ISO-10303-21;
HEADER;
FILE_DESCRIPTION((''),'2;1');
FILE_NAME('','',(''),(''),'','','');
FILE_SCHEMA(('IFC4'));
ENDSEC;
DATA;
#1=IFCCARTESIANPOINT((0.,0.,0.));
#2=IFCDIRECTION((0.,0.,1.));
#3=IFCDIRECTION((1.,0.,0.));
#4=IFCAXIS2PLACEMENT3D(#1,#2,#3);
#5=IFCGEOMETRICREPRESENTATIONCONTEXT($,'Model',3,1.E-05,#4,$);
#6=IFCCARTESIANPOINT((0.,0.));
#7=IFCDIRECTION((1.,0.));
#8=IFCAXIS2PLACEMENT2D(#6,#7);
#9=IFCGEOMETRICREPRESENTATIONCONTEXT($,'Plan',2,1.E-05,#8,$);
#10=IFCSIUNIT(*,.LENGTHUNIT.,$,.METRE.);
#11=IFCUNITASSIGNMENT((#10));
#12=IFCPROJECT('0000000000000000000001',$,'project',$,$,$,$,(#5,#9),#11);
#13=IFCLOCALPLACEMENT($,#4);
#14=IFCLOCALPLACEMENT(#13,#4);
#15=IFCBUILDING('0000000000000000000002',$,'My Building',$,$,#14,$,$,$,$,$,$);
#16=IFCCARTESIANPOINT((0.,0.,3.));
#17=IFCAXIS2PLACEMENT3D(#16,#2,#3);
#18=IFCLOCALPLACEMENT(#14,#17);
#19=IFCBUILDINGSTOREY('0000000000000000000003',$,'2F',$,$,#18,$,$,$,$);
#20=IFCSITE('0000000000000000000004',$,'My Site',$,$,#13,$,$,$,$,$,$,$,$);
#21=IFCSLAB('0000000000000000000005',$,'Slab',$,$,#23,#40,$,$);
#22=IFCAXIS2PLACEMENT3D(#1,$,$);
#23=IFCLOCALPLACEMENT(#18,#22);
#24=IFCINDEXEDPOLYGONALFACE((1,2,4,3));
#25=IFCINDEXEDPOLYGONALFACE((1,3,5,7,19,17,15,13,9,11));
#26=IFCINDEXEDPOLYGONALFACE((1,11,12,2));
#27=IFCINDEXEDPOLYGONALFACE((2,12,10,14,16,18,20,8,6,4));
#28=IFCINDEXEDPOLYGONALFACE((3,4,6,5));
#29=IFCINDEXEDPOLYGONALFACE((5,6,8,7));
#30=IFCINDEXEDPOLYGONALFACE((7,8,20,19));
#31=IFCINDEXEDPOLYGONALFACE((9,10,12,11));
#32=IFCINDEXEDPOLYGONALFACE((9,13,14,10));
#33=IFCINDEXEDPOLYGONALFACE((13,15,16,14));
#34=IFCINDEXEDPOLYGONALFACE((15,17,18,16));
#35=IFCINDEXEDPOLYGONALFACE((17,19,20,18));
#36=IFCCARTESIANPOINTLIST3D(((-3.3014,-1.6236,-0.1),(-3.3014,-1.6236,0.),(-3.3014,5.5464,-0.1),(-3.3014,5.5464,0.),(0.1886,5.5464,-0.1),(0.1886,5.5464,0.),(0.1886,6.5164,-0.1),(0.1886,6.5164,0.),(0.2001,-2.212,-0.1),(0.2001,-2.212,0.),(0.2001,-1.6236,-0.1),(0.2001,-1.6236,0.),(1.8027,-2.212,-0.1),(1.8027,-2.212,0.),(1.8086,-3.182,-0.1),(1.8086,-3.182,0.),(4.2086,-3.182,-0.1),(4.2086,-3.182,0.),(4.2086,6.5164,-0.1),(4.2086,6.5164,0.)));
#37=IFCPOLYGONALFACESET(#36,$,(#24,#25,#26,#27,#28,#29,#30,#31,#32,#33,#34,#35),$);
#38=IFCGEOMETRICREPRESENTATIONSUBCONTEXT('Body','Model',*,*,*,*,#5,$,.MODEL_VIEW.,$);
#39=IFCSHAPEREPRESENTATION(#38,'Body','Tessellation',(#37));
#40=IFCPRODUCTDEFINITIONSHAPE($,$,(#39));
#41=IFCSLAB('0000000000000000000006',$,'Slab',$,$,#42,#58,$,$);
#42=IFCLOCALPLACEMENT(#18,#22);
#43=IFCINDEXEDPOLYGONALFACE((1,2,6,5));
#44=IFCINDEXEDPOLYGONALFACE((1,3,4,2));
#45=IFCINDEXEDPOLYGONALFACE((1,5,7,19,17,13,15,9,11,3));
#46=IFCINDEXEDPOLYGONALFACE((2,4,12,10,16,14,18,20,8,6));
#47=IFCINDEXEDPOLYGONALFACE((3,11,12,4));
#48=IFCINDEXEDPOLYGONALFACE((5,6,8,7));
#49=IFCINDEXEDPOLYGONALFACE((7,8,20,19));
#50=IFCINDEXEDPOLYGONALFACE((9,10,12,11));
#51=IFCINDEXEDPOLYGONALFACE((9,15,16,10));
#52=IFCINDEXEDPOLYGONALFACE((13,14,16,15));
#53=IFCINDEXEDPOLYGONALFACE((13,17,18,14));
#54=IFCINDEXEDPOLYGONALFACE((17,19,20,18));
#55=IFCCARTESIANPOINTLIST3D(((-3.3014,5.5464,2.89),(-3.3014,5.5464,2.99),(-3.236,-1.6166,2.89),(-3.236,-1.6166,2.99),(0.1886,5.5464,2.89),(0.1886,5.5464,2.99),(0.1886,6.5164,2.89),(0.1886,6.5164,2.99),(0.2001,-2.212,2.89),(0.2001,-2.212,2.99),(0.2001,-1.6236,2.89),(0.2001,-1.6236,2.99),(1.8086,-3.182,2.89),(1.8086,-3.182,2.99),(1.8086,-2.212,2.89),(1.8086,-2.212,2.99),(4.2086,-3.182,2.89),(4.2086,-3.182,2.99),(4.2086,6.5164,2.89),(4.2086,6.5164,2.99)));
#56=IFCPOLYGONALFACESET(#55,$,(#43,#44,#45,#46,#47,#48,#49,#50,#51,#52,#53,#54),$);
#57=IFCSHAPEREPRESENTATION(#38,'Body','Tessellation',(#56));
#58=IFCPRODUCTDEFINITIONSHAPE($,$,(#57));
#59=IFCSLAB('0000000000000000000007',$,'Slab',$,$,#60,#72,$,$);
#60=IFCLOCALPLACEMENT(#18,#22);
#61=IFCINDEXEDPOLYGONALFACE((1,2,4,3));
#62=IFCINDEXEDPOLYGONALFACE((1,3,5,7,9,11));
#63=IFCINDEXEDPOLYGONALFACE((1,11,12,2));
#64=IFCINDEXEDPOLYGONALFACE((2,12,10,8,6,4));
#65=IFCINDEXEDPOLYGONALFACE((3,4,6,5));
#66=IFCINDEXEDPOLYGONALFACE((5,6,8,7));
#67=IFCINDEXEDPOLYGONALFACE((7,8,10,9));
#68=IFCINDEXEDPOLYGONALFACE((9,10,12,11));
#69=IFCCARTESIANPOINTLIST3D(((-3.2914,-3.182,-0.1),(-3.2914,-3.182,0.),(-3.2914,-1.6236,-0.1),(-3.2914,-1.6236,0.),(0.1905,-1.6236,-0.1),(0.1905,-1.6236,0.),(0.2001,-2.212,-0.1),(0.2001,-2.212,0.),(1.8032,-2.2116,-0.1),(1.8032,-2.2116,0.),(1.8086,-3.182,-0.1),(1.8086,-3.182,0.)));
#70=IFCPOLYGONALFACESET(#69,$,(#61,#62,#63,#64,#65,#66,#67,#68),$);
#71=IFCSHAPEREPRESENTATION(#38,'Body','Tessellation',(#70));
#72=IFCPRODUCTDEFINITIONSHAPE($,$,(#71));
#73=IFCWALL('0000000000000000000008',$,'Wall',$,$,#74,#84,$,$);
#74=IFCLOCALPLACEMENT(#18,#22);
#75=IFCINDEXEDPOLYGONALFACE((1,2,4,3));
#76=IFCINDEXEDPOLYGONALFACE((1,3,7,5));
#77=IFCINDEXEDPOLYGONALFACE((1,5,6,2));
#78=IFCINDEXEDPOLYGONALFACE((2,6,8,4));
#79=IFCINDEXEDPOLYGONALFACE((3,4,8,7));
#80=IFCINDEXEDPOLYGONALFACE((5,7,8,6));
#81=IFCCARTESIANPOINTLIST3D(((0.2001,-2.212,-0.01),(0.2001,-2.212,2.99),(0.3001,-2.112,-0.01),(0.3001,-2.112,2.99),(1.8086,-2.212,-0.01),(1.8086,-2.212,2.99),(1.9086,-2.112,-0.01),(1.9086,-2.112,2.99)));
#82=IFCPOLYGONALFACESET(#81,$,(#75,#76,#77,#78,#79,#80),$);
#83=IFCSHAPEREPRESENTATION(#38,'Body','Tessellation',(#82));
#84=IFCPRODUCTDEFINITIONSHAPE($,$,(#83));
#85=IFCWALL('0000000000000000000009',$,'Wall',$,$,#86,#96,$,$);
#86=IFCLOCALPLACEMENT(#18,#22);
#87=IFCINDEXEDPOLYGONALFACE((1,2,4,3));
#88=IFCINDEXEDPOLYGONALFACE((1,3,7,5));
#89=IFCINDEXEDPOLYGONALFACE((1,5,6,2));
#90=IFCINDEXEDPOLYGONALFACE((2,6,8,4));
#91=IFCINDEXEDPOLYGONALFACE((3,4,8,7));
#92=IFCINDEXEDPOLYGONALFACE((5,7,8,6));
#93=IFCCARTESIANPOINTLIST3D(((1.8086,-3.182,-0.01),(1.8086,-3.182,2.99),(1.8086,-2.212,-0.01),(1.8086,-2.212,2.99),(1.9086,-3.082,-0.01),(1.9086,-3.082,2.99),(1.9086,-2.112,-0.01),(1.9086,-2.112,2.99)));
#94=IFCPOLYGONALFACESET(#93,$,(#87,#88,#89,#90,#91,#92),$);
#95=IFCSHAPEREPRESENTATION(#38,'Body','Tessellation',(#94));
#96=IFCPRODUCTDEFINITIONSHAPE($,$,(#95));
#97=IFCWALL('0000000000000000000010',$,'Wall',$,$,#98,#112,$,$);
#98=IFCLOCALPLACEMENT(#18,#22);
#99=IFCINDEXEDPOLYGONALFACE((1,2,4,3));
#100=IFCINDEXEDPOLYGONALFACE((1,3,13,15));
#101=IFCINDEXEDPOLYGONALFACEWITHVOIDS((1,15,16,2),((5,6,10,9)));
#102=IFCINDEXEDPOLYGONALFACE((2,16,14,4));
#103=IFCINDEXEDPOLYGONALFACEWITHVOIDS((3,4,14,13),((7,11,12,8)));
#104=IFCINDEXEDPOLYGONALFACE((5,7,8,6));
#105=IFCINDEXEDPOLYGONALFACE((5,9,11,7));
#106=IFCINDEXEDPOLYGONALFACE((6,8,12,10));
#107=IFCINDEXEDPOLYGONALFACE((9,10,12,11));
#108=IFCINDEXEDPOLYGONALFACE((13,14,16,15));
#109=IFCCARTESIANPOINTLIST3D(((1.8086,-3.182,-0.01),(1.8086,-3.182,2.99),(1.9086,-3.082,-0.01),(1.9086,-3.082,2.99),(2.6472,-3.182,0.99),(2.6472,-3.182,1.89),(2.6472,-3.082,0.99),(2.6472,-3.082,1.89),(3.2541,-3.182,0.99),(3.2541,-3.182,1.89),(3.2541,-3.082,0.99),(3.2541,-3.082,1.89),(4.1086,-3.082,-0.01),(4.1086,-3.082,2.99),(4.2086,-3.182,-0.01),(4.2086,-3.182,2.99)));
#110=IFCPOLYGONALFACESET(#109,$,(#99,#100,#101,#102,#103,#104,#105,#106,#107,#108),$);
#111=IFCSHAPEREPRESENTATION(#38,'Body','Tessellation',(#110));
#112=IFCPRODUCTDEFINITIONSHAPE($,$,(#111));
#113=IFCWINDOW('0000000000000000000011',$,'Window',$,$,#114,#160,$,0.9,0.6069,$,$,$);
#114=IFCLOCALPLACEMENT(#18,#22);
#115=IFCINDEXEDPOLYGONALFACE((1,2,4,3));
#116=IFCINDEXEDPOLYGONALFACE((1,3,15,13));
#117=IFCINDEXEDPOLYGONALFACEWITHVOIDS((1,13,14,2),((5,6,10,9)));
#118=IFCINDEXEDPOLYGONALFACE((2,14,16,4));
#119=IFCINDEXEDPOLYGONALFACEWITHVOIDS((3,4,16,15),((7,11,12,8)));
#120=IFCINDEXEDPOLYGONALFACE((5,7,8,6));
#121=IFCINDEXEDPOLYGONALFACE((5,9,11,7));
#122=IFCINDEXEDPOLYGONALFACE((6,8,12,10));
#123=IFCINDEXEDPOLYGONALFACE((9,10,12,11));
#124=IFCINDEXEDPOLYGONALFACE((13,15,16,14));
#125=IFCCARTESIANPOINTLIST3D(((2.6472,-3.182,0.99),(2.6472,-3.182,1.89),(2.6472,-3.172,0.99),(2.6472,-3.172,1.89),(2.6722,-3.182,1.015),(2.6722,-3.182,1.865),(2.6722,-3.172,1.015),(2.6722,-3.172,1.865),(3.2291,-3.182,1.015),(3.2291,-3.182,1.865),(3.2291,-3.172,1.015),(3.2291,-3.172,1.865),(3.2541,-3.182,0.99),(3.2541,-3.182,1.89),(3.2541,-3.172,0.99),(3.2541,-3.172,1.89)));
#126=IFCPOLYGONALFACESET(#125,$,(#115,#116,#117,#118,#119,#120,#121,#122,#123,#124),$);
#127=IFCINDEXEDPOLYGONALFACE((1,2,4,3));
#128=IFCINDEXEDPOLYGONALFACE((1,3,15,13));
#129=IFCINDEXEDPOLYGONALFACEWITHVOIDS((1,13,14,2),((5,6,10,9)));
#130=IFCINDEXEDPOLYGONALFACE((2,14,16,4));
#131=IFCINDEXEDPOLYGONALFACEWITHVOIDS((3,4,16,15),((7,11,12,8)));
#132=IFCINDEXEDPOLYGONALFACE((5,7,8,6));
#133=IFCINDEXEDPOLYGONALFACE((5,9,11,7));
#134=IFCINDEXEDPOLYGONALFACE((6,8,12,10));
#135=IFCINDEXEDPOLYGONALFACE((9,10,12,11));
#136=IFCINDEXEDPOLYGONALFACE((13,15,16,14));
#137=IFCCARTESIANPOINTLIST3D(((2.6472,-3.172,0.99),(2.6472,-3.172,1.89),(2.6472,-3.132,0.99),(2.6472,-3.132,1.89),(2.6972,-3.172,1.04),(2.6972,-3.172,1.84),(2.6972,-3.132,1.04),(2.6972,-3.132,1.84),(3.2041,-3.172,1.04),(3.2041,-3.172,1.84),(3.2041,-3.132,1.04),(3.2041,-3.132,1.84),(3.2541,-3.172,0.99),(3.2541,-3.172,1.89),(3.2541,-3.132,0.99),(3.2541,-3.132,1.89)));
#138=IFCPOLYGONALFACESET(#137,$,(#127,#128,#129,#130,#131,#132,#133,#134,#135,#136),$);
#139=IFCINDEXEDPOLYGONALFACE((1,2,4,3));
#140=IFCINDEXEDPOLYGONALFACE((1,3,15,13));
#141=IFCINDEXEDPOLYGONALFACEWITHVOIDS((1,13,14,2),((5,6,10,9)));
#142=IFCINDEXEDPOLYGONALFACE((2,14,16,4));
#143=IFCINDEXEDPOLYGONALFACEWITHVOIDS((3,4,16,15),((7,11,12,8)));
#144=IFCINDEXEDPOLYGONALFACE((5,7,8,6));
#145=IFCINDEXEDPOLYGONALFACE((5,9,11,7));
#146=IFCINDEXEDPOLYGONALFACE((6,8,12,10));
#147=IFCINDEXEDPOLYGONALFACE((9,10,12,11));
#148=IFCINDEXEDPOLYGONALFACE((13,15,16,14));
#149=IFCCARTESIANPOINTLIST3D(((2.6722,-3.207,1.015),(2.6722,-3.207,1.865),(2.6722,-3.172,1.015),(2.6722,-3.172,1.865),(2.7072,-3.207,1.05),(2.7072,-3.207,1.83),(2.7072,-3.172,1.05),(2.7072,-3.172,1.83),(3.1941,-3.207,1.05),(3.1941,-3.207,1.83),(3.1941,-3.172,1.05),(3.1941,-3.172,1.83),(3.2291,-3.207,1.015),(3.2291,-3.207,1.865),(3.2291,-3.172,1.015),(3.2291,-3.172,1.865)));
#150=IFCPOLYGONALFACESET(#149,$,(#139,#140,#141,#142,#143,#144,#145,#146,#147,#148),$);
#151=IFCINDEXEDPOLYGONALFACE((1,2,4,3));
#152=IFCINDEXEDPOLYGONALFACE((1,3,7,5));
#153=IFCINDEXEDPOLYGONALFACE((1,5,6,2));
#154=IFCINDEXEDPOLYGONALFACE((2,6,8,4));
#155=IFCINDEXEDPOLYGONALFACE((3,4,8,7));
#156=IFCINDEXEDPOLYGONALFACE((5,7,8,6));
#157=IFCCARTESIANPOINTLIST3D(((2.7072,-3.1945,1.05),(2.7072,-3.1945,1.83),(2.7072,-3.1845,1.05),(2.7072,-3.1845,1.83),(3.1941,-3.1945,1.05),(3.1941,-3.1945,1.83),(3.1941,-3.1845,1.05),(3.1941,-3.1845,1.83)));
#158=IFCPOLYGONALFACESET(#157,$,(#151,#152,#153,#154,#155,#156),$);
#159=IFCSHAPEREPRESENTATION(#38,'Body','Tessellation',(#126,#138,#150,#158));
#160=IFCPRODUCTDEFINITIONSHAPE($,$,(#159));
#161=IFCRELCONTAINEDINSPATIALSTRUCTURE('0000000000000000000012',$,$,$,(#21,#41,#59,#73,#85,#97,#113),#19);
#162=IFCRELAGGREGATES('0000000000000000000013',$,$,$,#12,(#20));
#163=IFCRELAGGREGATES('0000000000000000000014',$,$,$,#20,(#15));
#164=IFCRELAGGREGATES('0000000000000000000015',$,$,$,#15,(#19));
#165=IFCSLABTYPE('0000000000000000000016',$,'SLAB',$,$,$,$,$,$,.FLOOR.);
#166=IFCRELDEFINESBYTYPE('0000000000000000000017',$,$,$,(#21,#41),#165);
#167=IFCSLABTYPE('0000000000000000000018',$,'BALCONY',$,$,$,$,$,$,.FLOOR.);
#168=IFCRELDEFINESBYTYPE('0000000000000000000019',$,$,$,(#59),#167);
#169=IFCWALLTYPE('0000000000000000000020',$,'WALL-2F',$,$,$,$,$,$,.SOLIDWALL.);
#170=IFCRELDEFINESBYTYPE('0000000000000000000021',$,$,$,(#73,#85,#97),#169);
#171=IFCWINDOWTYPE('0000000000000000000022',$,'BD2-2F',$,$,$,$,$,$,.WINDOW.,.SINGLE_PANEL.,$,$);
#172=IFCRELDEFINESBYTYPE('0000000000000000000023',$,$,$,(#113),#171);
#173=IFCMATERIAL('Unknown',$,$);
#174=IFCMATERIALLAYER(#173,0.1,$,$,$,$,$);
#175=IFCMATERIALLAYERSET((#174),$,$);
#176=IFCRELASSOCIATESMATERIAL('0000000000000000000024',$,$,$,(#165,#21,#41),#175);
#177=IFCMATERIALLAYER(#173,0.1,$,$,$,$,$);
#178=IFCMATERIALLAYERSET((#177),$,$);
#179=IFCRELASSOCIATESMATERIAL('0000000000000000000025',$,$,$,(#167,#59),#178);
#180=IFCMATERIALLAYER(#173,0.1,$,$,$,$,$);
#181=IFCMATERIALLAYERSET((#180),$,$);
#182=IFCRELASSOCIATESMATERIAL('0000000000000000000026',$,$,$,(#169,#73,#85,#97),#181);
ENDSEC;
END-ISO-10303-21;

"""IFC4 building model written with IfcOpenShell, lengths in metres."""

from ifc_helpers import new_model, entity, si_unit, frame, origin_with_axes, origin_2d_with_axis, place, context, subcontext, project, spatial, line, indexed_curve, outline, extrude, shape, source, transform, mapped, material, layer, layer_set, layer_usage, type_object, type_shapes, element, fill, save


model = new_model("IFC4")

# Units and contexts
model_context = context("Model", 3, precision=1e-05, world=origin_with_axes())
plan_context = context("Plan", 2, precision=1e-05, world=origin_2d_with_axis())
body_context_1 = subcontext(model_context, "Body", "Model", "MODEL_VIEW")
body_context_2 = subcontext(plan_context, "Body", "Plan", "PLAN_VIEW")
ifc_project = project(units=[si_unit("LENGTHUNIT", "METRE")], contexts=[model_context, plan_context])

# Site, building, storey
site_placement = place(None, origin_with_axes())
site = spatial("IfcSite", under=ifc_project, at=site_placement, Name="My Site")
building_placement = place(site_placement, origin_with_axes())
building = spatial("IfcBuilding", under=site, at=building_placement, Name="My Building")
storey_placement = place(building_placement, frame((0.0, 0.0, 3.0), z_axis=(0.0, 0.0, 1.0), x_axis=(1.0, 0.0, 0.0)))
storey = spatial("IfcBuildingStorey", under=building, at=storey_placement, Name="2F")

# Slabs
ifc_material_1 = material(Name="Unknown")
ifc_layer_1 = layer(ifc_material_1, 0.1)
ifc_layer_set_1 = layer_set([ifc_layer_1])
ifc_layer_usage_1 = layer_usage(ifc_layer_set_1, "AXIS3", "POSITIVE", -0.1)
slab_type_1 = type_object("IfcSlabType", Name="SLAB", PredefinedType="FLOOR", material=ifc_layer_set_1)
slab_1_placement = place(storey_placement, frame((4.2086, -3.182, 0.0), z_axis=(0.0, 0.0, 1.0), x_axis=(1.0, 0.0, 0.0)))
element("IfcSlab", 1, at=slab_1_placement, inside=storey, type_object=slab_type_1, material=ifc_layer_usage_1, Name="Slab", context=body_context_1, shape_type="SweptSolid", body=[
    extrude(outline(indexed_curve([(0.0, 0.0), (0.0, 9.6984), (-4.02, 9.6984), (-4.02, 8.7284), (-7.51, 8.7284), (-7.51, 1.5584), (-4.0085, 1.5584), (-4.0085, 0.97), (-2.4059, 0.97), (-2.4, 0.0), (0.0, 0.0)])), frame((0.0, 0.0, -0.1), z_axis=(0.0, 0.0, 1.0), x_axis=(1.0, 0.0, 0.0)), (0.0, 0.0, 1.0), 0.1),
])
ifc_layer_usage_2 = layer_usage(ifc_layer_set_1, "AXIS3", "POSITIVE", -0.1)
slab_2_placement = place(storey_placement, frame((0.2001, -1.6236, 2.99), z_axis=(0.0, 0.0, 1.0), x_axis=(1.0, 0.0, 0.0)))
element("IfcSlab", 2, at=slab_2_placement, inside=storey, type_object=slab_type_1, material=ifc_layer_usage_2, Name="Slab", context=body_context_1, shape_type="SweptSolid", body=[
    extrude(outline(indexed_curve([(0.0, 0.0), (0.0, -0.5884), (1.6085, -0.5884), (1.6085, -1.5584), (4.0085, -1.5584), (4.0085, 8.14), (-0.0115, 8.14), (-0.0115, 7.17), (-3.5015, 7.17), (-3.4362, 0.007), (0.0, 0.0)])), frame((0.0, 0.0, -0.1), z_axis=(0.0, 0.0, 1.0), x_axis=(1.0, 0.0, 0.0)), (0.0, 0.0, 1.0), 0.1),
])
ifc_layer_2 = layer(ifc_material_1, 0.1)
ifc_layer_set_2 = layer_set([ifc_layer_2])
ifc_layer_usage_3 = layer_usage(ifc_layer_set_2, "AXIS3", "POSITIVE", -0.1)
slab_type_2 = type_object("IfcSlabType", Name="BALCONY", PredefinedType="FLOOR", material=ifc_layer_set_2)
slab_3_placement = place(storey_placement, frame((1.8086, -3.182, 0.0), z_axis=(0.0, 0.0, 1.0), x_axis=(1.0, 0.0, 0.0)))
element("IfcSlab", 3, at=slab_3_placement, inside=storey, type_object=slab_type_2, material=ifc_layer_usage_3, Name="Slab", context=body_context_1, shape_type="SweptSolid", body=[
    extrude(outline(indexed_curve([(0.0, 0.0), (-5.1, 0.0), (-5.1, 1.5584), (-1.6181, 1.5584), (-1.6085, 0.97), (-0.0054, 0.9704), (0.0, 0.0)])), frame((0.0, 0.0, -0.1), z_axis=(0.0, 0.0, 1.0), x_axis=(1.0, 0.0, 0.0)), (0.0, 0.0, 1.0), 0.1),
])

# Walls
ifc_layer_3 = layer(ifc_material_1, 0.1)
ifc_layer_set_3 = layer_set([ifc_layer_3])
ifc_layer_usage_4 = layer_usage(ifc_layer_set_3, "AXIS2", "POSITIVE", 0.0)
wall_type = type_object("IfcWallType", Name="WALL-2F", PredefinedType="SOLIDWALL", material=ifc_layer_set_3)
wall_1_placement = place(storey_placement, frame((0.2001, -2.212, -0.01), z_axis=(0.0, 0.0, 1.0), x_axis=(1.0, 0.0, 0.0)))
element("IfcWall", 4, at=wall_1_placement, inside=storey, type_object=wall_type, material=ifc_layer_usage_4, Name="Wall", context=body_context_1, shape_type="SweptSolid", body=[
    extrude(outline(indexed_curve([(0.0, 0.0), (0.1, 0.1), (1.7085, 0.1), (1.6085, 0.0)], segments=[line(1, 2, 3, 4, 1)])), origin_with_axes(), (0.0, 0.0, 1.0), 3.0),
])
ifc_layer_usage_5 = layer_usage(ifc_layer_set_3, "AXIS2", "POSITIVE", 0.0)
wall_2_placement = place(storey_placement, frame((1.8086, -2.212, -0.01), z_axis=(0.0, 0.0, 1.0), x_axis=(0.0, -1.0, 0.0)))
element("IfcWall", 5, at=wall_2_placement, inside=storey, type_object=wall_type, material=ifc_layer_usage_5, Name="Wall", context=body_context_1, shape_type="SweptSolid", body=[
    extrude(outline(indexed_curve([(0.0, 0.0), (-0.1, 0.1), (0.87, 0.1), (0.97, 0.0)], segments=[line(1, 2, 3, 4, 1)])), origin_with_axes(), (0.0, 0.0, 1.0), 3.0),
])

# Wall, opening, window
ifc_layer_usage_6 = layer_usage(ifc_layer_set_3, "AXIS2", "POSITIVE", 0.0)
wall_3_placement = place(storey_placement, frame((1.8086, -3.182, -0.01), z_axis=(0.0, 0.0, 1.0), x_axis=(1.0, 0.0, 0.0)))
wall_3 = element("IfcWall", 6, at=wall_3_placement, inside=storey, type_object=wall_type, material=ifc_layer_usage_6, Name="Wall", context=body_context_1, shape_type="SweptSolid", body=[
    extrude(outline(indexed_curve([(0.0, 0.0), (0.1, 0.1), (2.3, 0.1), (2.4, 0.0)], segments=[line(1, 2, 3, 4, 1)])), origin_with_axes(), (0.0, 0.0, 1.0), 3.0),
])
shared_shape_1 = source(origin_with_axes(), body_context_1, "Body", "SweptSolid", [
    extrude(outline(indexed_curve([(0.0, 0.0), (0.6069, 0.0), (0.6069, 0.9), (0.0, 0.9)], segments=[line(1, 2, 3, 4, 1)])), frame((0.0, -0.6, 0.0), z_axis=(0.0, -1.0, 0.0), x_axis=(1.0, 0.0, 0.0)), (0.0, 0.0, -1.0), 1.2),
])
opening_placement = place(wall_3_placement, frame((1.4455, 0.1, 1.0), z_axis=(0.0, 0.0, 1.0), x_axis=(-1.0, 0.0, 0.0)))
opening = element("IfcOpeningElement", 7, at=opening_placement, cuts=wall_3, PredefinedType="OPENING", context=body_context_1, shape_type="MappedRepresentation", body=[
    mapped(shared_shape_1, transform((0.0, 0.0, 0.0), x_axis=(1.0, 0.0, 0.0), y_axis=(0.0, 1.0, 0.0), z_axis=(0.0, 0.0, 1.0), scale=1.0)),
])
window_type = type_object("IfcWindowType", Name="BD2-2F", PartitioningType="SINGLE_PANEL", PredefinedType="WINDOW")
shared_shape_2 = source(origin_with_axes(), body_context_1, "Body", "SweptSolid", [
    extrude(outline(indexed_curve([(0.0, 0.0), (0.6069, 0.0), (0.6069, 0.9), (0.0, 0.9)], segments=[line(1, 2, 3, 4, 1)]), holes=[indexed_curve([(0.025, 0.025), (0.5819, 0.025), (0.5819, 0.875), (0.025, 0.875)], segments=[line(1, 2, 3, 4, 1)])]), frame((0.0, 0.09, 0.0), z_axis=(0.0, -1.0, 0.0), x_axis=(1.0, 0.0, 0.0)), (0.0, 0.0, -1.0), 0.01),
    extrude(outline(indexed_curve([(0.0, 0.0), (0.6069, 0.0), (0.6069, 0.9), (0.0, 0.9)], segments=[line(1, 2, 3, 4, 1)]), holes=[indexed_curve([(0.05, 0.05), (0.5569, 0.05), (0.5569, 0.85), (0.05, 0.85)], segments=[line(1, 2, 3, 4, 1)])]), frame((0.0, 0.05, 0.0), z_axis=(0.0, -1.0, 0.0), x_axis=(1.0, 0.0, 0.0)), (0.0, 0.0, -1.0), 0.04),
    extrude(outline(indexed_curve([(0.0, 0.0), (0.5569, 0.0), (0.5569, 0.85), (0.0, 0.85)], segments=[line(1, 2, 3, 4, 1)]), holes=[indexed_curve([(0.035, 0.035), (0.5219, 0.035), (0.5219, 0.815), (0.035, 0.815)], segments=[line(1, 2, 3, 4, 1)])]), frame((0.025, 0.09, 0.025), z_axis=(0.0, -1.0, 0.0), x_axis=(1.0, 0.0, 0.0)), (0.0, 0.0, -1.0), 0.035),
    extrude(outline(indexed_curve([(0.035, 0.035), (0.5219, 0.035), (0.5219, 0.815), (0.035, 0.815)], segments=[line(1, 2, 3, 4, 1)])), frame((0.025, 0.1025, 0.025), z_axis=(0.0, -1.0, 0.0), x_axis=(1.0, 0.0, 0.0)), (0.0, 0.0, -1.0), 0.01),
])
shared_shape_3 = source(origin_with_axes(), body_context_2, "Body", "Curve2D", [
    entity("IfcIndexedPolyCurve", entity("IfcCartesianPointList2D", [[0.05, 0.05], [0.5569, 0.05]])),
    entity("IfcIndexedPolyCurve", entity("IfcCartesianPointList2D", [[0.0, 0.1], [0.025, 0.1], [0.025, 0.09], [0.05, 0.09], [0.05, 0.05], [0.0, 0.05]]), [entity("IfcLineIndex", [1, 2, 3, 4, 5, 6, 1])]),
    entity("IfcIndexedPolyCurve", entity("IfcCartesianPointList2D", [[0.6069, 0.1], [0.5819, 0.1], [0.5819, 0.09], [0.5569, 0.09], [0.5569, 0.05], [0.6069, 0.05]]), [entity("IfcLineIndex", [1, 2, 3, 4, 5, 6, 1])]),
    entity("IfcIndexedPolyCurve", entity("IfcCartesianPointList2D", [[0.025, 0.09], [0.06, 0.09], [0.06, 0.125], [0.025, 0.125]]), [entity("IfcLineIndex", [1, 2, 3, 4, 1])]),
    entity("IfcIndexedPolyCurve", entity("IfcCartesianPointList2D", [[0.5819, 0.09], [0.5469, 0.09], [0.5469, 0.125], [0.5819, 0.125]]), [entity("IfcLineIndex", [1, 2, 3, 4, 1])]),
    entity("IfcIndexedPolyCurve", entity("IfcCartesianPointList2D", [[0.06, 0.09], [0.5469, 0.09]])),
    entity("IfcIndexedPolyCurve", entity("IfcCartesianPointList2D", [[0.06, 0.125], [0.5469, 0.125]])),
    entity("IfcIndexedPolyCurve", entity("IfcCartesianPointList2D", [[0.06, 0.1075], [0.5469, 0.1075]])),
])
type_shapes(window_type, [shared_shape_2, shared_shape_3])
window_placement = place(opening_placement, origin_with_axes())
window = element("IfcWindow", 8, at=window_placement, inside=storey, type_object=window_type, Name="Window", OverallHeight=0.9, OverallWidth=0.6069, shapes=[
    shape(body_context_1, "Body", "MappedRepresentation", [mapped(shared_shape_2, transform((0.0, 0.0, 0.0), x_axis=(1.0, 0.0, 0.0), y_axis=(0.0, 1.0, 0.0), z_axis=(0.0, 0.0, 1.0), scale=1.0))]),
    shape(body_context_2, "Body", "MappedRepresentation", [mapped(shared_shape_3, transform((0.0, 0.0, 0.0), x_axis=(1.0, 0.0, 0.0), y_axis=(0.0, 1.0, 0.0), z_axis=(0.0, 0.0, 1.0), scale=1.0))]),
])
fill(opening, window)

save(model, "model.ifc")
